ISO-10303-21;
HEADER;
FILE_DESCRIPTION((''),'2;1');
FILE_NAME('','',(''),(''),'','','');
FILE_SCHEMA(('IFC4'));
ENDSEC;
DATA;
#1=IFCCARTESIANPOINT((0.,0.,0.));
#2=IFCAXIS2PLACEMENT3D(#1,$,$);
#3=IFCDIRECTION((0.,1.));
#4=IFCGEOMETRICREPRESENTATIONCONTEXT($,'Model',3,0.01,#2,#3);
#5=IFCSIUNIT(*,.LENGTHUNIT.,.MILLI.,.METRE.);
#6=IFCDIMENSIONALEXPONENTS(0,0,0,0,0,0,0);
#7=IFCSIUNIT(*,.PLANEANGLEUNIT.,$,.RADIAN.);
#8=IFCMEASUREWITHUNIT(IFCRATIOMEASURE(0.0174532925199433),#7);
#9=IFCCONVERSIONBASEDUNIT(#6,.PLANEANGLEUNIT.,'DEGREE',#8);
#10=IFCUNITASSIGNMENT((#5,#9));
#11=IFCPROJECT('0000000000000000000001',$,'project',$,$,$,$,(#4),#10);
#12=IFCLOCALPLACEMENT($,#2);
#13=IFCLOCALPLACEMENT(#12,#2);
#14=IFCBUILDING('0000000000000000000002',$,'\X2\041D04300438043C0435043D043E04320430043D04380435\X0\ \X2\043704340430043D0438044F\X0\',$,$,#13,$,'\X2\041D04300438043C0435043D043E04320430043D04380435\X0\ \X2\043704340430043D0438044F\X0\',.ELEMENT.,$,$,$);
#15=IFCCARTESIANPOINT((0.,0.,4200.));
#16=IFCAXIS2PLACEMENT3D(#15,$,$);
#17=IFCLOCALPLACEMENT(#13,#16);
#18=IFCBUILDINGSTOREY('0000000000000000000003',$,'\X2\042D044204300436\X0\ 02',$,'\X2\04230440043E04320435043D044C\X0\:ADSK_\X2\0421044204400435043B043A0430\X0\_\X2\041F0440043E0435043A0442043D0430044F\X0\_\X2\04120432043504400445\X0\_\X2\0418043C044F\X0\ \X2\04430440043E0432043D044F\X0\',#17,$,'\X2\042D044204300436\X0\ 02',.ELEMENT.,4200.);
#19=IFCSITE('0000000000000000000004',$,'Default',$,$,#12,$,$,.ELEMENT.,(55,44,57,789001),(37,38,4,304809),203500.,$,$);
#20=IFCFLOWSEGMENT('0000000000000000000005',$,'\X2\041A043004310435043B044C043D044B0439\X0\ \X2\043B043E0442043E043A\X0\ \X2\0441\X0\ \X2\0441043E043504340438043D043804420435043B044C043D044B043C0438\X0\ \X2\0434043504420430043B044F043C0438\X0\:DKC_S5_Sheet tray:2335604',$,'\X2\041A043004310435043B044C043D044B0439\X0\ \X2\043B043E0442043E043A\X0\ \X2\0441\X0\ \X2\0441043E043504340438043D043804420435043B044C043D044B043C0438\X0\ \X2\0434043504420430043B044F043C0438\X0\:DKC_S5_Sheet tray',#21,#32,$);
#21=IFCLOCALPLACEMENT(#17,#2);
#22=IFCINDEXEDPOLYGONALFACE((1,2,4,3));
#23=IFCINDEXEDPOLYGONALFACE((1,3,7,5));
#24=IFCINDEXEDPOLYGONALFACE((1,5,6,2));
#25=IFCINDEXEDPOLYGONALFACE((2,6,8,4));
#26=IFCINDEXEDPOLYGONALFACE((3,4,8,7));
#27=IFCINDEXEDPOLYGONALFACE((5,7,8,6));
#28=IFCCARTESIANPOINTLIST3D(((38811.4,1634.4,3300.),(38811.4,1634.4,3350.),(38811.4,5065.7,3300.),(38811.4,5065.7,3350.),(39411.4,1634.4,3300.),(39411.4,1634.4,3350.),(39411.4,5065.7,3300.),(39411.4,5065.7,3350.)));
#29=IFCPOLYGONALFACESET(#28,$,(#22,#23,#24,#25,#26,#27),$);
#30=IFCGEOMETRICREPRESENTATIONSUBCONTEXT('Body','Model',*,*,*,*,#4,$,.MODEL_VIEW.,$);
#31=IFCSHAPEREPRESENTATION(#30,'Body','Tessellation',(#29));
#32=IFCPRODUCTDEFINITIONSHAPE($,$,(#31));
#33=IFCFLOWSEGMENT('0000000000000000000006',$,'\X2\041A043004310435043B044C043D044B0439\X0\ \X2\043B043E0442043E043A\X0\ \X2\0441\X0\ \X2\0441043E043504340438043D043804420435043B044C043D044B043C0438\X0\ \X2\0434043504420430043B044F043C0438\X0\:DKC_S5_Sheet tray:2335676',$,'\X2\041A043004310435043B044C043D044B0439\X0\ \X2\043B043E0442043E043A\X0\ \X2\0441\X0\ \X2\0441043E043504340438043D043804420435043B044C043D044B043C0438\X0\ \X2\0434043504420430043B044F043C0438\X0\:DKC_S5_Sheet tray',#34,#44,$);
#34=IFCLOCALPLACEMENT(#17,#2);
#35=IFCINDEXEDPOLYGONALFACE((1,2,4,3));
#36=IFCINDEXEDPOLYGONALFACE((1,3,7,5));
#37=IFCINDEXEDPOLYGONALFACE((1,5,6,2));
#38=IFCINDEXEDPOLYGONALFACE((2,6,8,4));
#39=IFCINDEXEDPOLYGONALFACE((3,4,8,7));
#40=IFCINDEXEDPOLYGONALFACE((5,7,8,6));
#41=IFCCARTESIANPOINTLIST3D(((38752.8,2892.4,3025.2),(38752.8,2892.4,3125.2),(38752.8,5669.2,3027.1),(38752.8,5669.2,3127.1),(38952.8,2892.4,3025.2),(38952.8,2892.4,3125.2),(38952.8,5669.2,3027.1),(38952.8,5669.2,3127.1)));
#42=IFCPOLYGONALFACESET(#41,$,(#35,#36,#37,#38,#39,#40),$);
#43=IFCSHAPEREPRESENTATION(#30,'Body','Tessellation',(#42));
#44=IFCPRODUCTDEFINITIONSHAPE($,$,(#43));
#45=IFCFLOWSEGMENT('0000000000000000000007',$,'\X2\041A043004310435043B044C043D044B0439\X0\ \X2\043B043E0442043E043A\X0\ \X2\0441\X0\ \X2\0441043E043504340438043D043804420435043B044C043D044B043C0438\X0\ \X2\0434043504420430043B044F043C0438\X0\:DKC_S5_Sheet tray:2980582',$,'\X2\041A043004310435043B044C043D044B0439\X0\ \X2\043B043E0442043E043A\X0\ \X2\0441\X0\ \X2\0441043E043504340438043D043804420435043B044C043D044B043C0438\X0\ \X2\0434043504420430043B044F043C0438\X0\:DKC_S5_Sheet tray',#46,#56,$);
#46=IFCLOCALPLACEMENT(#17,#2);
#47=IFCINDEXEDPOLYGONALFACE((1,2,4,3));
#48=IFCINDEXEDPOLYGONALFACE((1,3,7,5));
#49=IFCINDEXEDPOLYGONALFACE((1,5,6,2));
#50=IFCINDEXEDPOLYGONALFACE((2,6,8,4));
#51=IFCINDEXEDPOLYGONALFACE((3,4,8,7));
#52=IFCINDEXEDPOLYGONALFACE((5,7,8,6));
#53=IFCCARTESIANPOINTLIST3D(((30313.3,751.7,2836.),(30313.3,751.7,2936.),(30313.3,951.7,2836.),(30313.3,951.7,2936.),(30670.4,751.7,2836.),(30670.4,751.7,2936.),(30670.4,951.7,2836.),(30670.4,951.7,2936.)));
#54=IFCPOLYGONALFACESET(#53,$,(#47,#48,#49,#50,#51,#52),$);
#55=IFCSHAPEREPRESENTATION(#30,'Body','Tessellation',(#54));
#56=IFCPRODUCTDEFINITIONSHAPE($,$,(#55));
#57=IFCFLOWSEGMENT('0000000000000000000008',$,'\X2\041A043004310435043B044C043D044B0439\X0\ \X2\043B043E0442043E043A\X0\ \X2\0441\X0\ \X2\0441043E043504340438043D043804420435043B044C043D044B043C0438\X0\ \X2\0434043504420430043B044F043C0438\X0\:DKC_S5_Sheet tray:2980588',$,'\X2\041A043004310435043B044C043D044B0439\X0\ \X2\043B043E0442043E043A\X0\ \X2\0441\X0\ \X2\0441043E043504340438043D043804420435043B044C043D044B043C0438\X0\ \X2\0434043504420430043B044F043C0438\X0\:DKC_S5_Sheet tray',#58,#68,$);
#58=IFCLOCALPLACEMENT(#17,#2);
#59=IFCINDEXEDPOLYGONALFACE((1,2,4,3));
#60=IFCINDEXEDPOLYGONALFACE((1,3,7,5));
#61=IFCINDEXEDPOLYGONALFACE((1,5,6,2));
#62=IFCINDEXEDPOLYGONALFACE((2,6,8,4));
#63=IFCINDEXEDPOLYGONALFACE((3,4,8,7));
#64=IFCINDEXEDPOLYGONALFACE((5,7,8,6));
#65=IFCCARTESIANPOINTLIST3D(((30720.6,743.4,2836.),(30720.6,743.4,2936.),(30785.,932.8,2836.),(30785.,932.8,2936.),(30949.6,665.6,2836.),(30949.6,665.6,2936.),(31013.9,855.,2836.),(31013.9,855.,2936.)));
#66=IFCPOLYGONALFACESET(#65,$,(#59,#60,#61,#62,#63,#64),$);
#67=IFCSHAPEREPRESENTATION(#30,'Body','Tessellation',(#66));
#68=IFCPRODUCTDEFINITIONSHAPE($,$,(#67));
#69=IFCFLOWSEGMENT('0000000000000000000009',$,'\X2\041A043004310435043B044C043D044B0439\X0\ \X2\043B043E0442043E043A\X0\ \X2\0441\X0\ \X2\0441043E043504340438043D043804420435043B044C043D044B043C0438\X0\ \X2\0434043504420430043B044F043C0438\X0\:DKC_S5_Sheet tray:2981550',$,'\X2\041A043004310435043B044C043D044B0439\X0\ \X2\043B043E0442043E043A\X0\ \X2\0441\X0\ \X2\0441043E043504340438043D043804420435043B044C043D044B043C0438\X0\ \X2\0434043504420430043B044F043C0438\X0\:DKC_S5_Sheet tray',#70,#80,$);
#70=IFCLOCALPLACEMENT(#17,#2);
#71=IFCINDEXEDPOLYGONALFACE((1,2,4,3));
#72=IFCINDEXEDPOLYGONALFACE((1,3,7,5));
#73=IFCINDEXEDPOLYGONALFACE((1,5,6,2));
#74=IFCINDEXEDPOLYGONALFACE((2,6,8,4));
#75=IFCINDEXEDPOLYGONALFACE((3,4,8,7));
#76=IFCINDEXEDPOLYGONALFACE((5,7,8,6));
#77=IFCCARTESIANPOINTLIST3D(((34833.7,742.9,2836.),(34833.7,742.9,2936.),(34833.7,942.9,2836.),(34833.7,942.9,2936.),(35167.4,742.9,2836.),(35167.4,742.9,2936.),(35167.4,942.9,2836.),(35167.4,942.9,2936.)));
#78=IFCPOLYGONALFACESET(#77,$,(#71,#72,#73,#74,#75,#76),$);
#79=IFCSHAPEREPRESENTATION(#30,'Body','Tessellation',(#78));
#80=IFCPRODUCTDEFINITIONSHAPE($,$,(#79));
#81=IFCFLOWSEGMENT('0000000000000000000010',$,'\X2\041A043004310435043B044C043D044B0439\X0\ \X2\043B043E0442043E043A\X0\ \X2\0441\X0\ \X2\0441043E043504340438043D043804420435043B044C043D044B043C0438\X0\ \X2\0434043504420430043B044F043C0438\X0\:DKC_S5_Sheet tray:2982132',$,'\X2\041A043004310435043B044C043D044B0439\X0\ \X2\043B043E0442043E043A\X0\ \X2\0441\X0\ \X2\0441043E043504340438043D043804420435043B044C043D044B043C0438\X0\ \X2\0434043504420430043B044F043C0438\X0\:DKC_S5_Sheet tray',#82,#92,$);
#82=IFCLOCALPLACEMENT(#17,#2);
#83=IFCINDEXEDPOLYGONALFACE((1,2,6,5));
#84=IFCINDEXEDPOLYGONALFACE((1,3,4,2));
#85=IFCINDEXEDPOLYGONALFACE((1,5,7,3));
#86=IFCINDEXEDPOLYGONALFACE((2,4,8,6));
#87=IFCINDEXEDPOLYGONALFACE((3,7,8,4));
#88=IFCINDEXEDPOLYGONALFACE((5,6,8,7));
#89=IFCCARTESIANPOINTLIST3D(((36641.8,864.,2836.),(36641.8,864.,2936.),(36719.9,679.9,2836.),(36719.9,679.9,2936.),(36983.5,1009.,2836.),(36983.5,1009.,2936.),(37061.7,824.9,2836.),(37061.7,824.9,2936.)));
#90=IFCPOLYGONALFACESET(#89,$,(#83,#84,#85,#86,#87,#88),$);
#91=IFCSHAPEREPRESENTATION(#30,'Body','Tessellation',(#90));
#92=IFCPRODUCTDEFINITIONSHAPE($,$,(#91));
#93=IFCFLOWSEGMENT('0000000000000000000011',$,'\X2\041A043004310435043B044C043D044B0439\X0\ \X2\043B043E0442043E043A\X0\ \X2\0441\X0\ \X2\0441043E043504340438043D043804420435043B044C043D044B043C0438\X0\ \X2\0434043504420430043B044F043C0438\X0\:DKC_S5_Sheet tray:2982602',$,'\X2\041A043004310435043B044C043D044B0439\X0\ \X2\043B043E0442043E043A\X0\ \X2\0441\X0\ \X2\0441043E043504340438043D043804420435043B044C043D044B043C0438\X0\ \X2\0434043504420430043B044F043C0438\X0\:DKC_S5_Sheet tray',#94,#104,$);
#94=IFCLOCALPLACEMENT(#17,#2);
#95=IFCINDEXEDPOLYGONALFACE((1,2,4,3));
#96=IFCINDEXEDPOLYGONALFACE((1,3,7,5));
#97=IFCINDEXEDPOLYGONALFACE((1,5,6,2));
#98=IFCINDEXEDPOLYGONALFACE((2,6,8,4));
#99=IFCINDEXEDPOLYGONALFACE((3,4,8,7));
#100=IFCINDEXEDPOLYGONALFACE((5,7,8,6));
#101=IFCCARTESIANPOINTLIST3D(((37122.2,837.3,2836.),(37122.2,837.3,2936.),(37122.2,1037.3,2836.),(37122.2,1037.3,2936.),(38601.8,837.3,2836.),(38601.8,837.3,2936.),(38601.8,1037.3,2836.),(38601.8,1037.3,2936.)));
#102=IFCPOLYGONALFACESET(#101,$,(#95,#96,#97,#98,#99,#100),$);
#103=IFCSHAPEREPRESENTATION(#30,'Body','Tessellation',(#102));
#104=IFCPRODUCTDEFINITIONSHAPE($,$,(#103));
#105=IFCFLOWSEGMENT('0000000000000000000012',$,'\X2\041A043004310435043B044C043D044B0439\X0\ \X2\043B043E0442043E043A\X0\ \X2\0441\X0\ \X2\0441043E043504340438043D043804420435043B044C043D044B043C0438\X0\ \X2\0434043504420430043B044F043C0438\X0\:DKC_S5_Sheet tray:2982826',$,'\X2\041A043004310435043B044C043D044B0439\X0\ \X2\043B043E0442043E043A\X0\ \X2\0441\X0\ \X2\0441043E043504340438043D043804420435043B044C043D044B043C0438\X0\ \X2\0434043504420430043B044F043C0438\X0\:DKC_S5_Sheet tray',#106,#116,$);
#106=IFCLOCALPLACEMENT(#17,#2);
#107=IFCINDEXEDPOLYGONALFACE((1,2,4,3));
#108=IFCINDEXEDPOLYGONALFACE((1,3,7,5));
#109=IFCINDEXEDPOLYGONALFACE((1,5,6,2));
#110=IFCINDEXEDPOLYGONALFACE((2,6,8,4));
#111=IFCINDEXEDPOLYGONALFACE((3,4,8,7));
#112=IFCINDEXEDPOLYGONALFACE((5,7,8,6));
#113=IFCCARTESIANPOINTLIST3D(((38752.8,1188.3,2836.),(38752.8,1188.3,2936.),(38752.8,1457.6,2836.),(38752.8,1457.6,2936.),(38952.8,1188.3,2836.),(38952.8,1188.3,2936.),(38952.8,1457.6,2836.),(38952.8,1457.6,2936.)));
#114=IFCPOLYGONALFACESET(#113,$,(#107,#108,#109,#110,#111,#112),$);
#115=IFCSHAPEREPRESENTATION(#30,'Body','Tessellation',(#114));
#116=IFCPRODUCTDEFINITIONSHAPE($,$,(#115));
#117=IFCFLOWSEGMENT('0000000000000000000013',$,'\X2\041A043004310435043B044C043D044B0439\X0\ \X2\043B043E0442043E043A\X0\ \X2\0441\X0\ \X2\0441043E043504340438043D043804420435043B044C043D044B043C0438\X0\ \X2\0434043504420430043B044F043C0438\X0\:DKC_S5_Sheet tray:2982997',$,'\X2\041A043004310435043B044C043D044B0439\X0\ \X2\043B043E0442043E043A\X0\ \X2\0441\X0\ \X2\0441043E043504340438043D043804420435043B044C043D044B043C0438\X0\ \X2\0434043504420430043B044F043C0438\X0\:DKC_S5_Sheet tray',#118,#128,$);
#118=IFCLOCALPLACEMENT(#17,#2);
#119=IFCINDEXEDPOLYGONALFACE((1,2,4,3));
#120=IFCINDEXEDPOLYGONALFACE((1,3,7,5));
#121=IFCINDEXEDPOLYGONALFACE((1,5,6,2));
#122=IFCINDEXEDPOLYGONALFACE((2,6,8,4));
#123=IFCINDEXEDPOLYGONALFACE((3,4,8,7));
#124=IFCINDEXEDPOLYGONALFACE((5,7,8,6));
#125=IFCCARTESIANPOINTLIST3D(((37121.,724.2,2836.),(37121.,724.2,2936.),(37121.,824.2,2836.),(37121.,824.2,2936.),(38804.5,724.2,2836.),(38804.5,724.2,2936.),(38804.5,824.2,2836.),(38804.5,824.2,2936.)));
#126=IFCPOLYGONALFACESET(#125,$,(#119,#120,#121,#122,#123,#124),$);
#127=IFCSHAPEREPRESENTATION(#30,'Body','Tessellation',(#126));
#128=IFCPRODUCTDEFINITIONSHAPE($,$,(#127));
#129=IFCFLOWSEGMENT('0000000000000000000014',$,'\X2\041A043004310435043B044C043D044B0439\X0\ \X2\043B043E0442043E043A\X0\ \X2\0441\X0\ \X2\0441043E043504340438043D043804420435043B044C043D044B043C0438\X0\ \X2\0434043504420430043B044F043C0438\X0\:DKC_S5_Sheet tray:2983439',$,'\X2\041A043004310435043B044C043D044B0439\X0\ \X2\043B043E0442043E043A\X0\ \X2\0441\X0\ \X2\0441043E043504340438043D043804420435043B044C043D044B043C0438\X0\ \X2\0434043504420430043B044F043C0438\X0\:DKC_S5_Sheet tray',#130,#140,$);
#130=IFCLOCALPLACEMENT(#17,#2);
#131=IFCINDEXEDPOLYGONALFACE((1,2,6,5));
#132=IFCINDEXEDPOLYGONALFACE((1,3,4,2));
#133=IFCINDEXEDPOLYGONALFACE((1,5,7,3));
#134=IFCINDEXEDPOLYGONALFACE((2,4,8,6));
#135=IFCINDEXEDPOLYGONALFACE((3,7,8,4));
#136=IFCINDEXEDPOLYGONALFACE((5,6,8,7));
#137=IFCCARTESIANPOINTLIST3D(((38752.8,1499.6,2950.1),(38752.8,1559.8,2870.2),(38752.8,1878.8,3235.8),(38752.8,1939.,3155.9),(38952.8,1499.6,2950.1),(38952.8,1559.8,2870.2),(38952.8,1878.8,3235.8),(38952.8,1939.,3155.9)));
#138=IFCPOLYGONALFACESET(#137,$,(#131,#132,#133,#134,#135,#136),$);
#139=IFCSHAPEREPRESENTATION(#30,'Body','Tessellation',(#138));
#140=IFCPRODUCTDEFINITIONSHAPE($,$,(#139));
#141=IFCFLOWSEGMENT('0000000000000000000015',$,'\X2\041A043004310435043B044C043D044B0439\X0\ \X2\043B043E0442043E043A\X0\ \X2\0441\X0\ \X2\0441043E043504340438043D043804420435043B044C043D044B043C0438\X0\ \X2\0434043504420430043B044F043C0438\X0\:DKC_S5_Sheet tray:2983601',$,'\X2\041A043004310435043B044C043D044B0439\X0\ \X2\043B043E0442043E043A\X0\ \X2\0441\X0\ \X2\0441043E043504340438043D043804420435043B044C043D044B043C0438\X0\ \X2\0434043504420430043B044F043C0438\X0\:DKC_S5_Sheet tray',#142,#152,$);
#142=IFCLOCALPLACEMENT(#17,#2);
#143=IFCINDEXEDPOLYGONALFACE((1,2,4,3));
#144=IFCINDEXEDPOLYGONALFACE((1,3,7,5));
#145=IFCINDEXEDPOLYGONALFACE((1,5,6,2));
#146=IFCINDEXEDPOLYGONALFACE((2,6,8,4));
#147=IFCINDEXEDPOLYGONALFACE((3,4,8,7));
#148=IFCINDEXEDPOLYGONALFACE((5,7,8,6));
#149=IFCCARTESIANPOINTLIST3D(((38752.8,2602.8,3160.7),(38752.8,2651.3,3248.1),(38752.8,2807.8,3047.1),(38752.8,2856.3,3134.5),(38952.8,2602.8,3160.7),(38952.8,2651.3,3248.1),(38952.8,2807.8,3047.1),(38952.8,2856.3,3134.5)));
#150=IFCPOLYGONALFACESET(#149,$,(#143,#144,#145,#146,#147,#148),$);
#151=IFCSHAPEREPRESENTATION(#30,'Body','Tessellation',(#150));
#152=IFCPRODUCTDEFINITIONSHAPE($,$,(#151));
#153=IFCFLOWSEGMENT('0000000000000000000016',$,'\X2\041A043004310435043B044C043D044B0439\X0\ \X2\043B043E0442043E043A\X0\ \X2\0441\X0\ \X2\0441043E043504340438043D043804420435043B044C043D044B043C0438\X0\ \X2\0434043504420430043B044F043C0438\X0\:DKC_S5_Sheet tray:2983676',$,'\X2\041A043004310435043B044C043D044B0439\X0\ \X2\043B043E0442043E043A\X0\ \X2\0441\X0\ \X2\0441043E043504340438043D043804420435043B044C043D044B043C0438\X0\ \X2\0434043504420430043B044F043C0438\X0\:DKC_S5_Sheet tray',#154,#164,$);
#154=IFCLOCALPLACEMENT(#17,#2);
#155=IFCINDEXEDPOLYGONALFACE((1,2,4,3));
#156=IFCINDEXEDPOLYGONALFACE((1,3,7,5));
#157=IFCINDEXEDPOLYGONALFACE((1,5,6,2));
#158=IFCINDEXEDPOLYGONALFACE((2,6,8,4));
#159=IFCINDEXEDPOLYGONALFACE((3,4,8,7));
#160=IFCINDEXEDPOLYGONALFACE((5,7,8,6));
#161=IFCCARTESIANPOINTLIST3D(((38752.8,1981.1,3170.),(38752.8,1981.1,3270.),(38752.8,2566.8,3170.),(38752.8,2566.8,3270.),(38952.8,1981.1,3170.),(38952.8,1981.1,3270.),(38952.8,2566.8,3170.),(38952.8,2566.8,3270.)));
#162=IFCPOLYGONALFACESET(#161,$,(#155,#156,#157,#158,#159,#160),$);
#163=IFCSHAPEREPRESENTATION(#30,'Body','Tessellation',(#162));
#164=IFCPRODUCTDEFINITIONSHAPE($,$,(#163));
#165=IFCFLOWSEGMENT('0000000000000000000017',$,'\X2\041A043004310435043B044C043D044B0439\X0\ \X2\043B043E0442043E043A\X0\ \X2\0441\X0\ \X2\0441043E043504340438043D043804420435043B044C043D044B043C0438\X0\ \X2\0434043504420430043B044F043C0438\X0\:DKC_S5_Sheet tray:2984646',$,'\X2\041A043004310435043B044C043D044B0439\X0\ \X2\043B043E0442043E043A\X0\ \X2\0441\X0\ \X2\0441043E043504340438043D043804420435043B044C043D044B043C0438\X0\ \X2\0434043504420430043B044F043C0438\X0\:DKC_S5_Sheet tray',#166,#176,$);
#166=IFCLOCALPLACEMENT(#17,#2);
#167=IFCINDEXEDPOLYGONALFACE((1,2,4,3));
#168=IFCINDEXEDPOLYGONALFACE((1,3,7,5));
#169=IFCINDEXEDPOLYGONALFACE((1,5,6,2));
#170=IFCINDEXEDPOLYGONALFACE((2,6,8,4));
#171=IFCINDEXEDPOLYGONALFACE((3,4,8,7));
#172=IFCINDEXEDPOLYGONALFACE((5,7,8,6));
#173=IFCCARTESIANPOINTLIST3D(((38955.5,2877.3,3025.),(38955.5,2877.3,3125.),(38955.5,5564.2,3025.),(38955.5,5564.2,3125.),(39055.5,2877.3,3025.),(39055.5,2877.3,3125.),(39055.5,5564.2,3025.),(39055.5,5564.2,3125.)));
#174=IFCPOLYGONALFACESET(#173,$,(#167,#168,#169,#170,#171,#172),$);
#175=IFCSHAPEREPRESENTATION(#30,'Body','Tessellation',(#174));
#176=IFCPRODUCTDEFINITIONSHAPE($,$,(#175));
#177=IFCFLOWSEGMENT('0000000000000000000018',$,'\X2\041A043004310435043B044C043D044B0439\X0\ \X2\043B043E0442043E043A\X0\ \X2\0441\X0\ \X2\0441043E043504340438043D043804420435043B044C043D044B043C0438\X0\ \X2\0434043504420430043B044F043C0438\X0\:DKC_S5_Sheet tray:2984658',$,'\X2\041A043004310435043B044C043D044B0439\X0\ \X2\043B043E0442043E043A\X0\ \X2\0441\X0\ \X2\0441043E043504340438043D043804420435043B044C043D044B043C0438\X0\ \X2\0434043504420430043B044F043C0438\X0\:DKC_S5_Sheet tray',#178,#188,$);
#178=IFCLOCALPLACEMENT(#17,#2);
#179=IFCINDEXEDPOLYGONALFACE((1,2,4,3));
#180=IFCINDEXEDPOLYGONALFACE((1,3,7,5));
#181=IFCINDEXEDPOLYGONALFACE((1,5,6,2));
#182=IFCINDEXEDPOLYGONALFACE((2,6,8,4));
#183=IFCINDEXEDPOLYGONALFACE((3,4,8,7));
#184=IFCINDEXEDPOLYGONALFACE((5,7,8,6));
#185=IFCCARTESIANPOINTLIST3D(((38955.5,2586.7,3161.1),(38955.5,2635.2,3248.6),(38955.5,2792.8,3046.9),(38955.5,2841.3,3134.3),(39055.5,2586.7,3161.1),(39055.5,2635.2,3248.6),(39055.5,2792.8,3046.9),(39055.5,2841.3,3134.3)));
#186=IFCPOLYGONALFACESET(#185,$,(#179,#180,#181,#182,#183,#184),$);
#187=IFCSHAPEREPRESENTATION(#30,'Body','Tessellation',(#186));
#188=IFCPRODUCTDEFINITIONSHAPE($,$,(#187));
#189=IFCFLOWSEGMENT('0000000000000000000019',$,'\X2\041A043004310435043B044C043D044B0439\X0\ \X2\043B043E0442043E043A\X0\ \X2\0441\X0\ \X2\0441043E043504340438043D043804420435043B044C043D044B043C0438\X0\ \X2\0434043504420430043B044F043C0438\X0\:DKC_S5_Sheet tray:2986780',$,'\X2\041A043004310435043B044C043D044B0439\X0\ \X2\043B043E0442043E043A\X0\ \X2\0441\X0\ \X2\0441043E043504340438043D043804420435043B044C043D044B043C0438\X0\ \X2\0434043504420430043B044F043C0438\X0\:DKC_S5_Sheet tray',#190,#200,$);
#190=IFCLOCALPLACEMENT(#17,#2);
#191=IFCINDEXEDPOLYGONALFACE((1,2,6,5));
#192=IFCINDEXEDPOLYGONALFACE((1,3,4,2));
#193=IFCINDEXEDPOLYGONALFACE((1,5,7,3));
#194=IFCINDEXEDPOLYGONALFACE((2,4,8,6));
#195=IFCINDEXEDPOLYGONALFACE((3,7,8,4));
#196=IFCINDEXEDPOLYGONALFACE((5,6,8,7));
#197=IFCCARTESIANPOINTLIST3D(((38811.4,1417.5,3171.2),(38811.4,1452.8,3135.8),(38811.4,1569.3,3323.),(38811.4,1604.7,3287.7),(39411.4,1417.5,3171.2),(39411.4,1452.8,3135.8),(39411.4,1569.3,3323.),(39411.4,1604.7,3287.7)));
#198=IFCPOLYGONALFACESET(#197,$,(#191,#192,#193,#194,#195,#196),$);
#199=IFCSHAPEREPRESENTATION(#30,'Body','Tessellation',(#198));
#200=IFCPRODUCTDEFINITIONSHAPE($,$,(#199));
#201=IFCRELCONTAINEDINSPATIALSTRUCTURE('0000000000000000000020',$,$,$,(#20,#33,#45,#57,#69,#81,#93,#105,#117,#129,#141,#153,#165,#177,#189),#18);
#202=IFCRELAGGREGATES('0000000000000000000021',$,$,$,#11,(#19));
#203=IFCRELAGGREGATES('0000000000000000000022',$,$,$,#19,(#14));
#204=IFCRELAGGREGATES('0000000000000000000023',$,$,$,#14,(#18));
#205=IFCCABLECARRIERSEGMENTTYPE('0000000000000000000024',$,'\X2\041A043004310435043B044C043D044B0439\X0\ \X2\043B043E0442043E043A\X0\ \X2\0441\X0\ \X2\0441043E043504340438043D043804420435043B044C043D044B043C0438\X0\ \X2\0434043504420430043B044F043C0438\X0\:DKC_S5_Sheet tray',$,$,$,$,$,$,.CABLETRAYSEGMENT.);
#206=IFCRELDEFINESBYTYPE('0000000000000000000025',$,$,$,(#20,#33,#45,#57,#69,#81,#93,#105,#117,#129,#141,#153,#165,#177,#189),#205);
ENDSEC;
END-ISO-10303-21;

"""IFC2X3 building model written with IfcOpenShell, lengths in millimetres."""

from ifc_helpers import new_model, entity, si_unit, converted_unit, direction, frame, frame_2d, origin, origin_2d_with_axis, place, context, subcontext, project, spatial, rectangle, extrude, type_object, element, save


model = new_model("IFC2X3")

# Units and contexts
model_context = context("Model", 3, precision=0.01, world=origin(), true_north=direction((0.0, 1.0)))
body_context = subcontext(model_context, "Body", "Model", "MODEL_VIEW")
ifc_project = project(units=[si_unit("LENGTHUNIT", "METRE", prefix="MILLI"), converted_unit("PLANEANGLEUNIT", "DEGREE", entity("IfcRatioMeasure", 0.0174532925199433), si_unit("PLANEANGLEUNIT", "RADIAN"), dimensions=[0, 0, 0, 0, 0, 0, 0])], contexts=[model_context])

# Site, building, storey
site_placement = place(None, frame((0.0, 0.0, 0.0)))
site = spatial("IfcSite", under=ifc_project, at=site_placement, Name="Default", CompositionType="ELEMENT", RefLatitude=(55, 44, 57, 789001), RefLongitude=(37, 38, 4, 304809), RefElevation=203500.0)
building_placement = place(site_placement, origin())
building = spatial("IfcBuilding", under=site, at=building_placement, Name="Наименование здания", LongName="Наименование здания", CompositionType="ELEMENT")
storey_placement = place(building_placement, frame((0.0, 0.0, 4200.0)))
storey = spatial("IfcBuildingStorey", under=building, at=storey_placement, Name="Этаж 02", ObjectType="Уровень:ADSK_Стрелка_Проектная_Вверх_Имя уровня", LongName="Этаж 02", CompositionType="ELEMENT", Elevation=4200.0)

# Flow segments
cable_carrier_segment_type = type_object("IfcCableCarrierSegmentType", Name="Кабельный лоток с соединительными деталями:DKC_S5_Sheet tray", PredefinedType="CABLETRAYSEGMENT")
flow_segment_1_placement = place(storey_placement, frame((38811.4, 1634.4, 3300.0)))
element("IfcFlowSegment", 1, at=flow_segment_1_placement, inside=storey, type_object=cable_carrier_segment_type, Name="Кабельный лоток с соединительными деталями:DKC_S5_Sheet tray:2335604", ObjectType="Кабельный лоток с соединительными деталями:DKC_S5_Sheet tray", context=body_context, shape_type="SweptSolid", body=[
    extrude(rectangle(XDim=3431.2, YDim=600.0, at=origin_2d_with_axis()), frame((300.0, 1715.6, 0.0), z_axis=(0.0, 0.0, 1.0), x_axis=(0.0, -1.0, 0.0)), (0.0, 0.0, 1.0), 50.0),
])
flow_segment_2_placement = place(storey_placement, frame((38752.8, 2892.4, 3025.2)))
element("IfcFlowSegment", 2, at=flow_segment_2_placement, inside=storey, type_object=cable_carrier_segment_type, Name="Кабельный лоток с соединительными деталями:DKC_S5_Sheet tray:2335676", ObjectType="Кабельный лоток с соединительными деталями:DKC_S5_Sheet tray", context=body_context, shape_type="SweptSolid", body=[
    extrude(rectangle(XDim=2776.8, YDim=200.0, at=origin_2d_with_axis()), frame((100.0, 1388.5, 1.0), z_axis=(0.0, -0.000692, 1.0), x_axis=(0.0, -1.0, -0.000692)), (0.0, 0.0, 1.0), 100.0),
])
flow_segment_3_placement = place(storey_placement, frame((30313.3, 751.7, 2836.0)))
element("IfcFlowSegment", 3, at=flow_segment_3_placement, inside=storey, type_object=cable_carrier_segment_type, Name="Кабельный лоток с соединительными деталями:DKC_S5_Sheet tray:2980582", ObjectType="Кабельный лоток с соединительными деталями:DKC_S5_Sheet tray", context=body_context, shape_type="SweptSolid", body=[
    extrude(rectangle(XDim=357.1, YDim=200.0, at=frame_2d((0.0, 0.0), x_axis=(1.0, 0.0))), frame((178.5, 100.0, 0.0)), (0.0, 0.0, 1.0), 100.0),
])
flow_segment_4_placement = place(storey_placement, frame((30720.6, 665.6, 2836.0)))
element("IfcFlowSegment", 4, at=flow_segment_4_placement, inside=storey, type_object=cable_carrier_segment_type, Name="Кабельный лоток с соединительными деталями:DKC_S5_Sheet tray:2980588", ObjectType="Кабельный лоток с соединительными деталями:DKC_S5_Sheet tray", context=body_context, shape_type="SweptSolid", body=[
    extrude(rectangle(XDim=241.8, YDim=200.0, at=frame_2d((0.0, 0.0), x_axis=(1.0, 0.0))), frame((146.6, 133.6, 0.0), z_axis=(0.0, 0.0, 1.0), x_axis=(0.946792, -0.321847, 0.0)), (0.0, 0.0, 1.0), 100.0),
])
flow_segment_5_placement = place(storey_placement, frame((34833.7, 742.9, 2836.0)))
element("IfcFlowSegment", 5, at=flow_segment_5_placement, inside=storey, type_object=cable_carrier_segment_type, Name="Кабельный лоток с соединительными деталями:DKC_S5_Sheet tray:2981550", ObjectType="Кабельный лоток с соединительными деталями:DKC_S5_Sheet tray", context=body_context, shape_type="SweptSolid", body=[
    extrude(rectangle(XDim=333.7, YDim=200.0, at=frame_2d((0.0, 0.0), x_axis=(1.0, 0.0))), frame((166.8, 100.0, 0.0)), (0.0, 0.0, 1.0), 100.0),
])
flow_segment_6_placement = place(storey_placement, frame((36641.8, 679.9, 2836.0)))
element("IfcFlowSegment", 6, at=flow_segment_6_placement, inside=storey, type_object=cable_carrier_segment_type, Name="Кабельный лоток с соединительными деталями:DKC_S5_Sheet tray:2982132", ObjectType="Кабельный лоток с соединительными деталями:DKC_S5_Sheet tray", context=body_context, shape_type="SweptSolid", body=[
    extrude(rectangle(XDim=371.3, YDim=200.0, at=origin_2d_with_axis()), frame((210.0, 164.6, 0.0), z_axis=(0.0, 0.0, 1.0), x_axis=(0.920505, 0.390731, 0.0)), (0.0, 0.0, 1.0), 100.0),
])
flow_segment_7_placement = place(storey_placement, frame((37122.2, 837.3, 2836.0)))
element("IfcFlowSegment", 7, at=flow_segment_7_placement, inside=storey, type_object=cable_carrier_segment_type, Name="Кабельный лоток с соединительными деталями:DKC_S5_Sheet tray:2982602", ObjectType="Кабельный лоток с соединительными деталями:DKC_S5_Sheet tray", context=body_context, shape_type="SweptSolid", body=[
    extrude(rectangle(XDim=1479.6, YDim=200.0, at=origin_2d_with_axis()), frame((739.8, 100.0, 0.0)), (0.0, 0.0, 1.0), 100.0),
])
flow_segment_8_placement = place(storey_placement, frame((38752.8, 1188.3, 2836.0)))
element("IfcFlowSegment", 8, at=flow_segment_8_placement, inside=storey, type_object=cable_carrier_segment_type, Name="Кабельный лоток с соединительными деталями:DKC_S5_Sheet tray:2982826", ObjectType="Кабельный лоток с соединительными деталями:DKC_S5_Sheet tray", context=body_context, shape_type="SweptSolid", body=[
    extrude(rectangle(XDim=269.3, YDim=200.0, at=frame_2d((0.0, 0.0), x_axis=(1.0, 0.0))), frame((100.0, 134.6, 0.0), z_axis=(0.0, 0.0, 1.0), x_axis=(0.0, 1.0, 0.0)), (0.0, 0.0, 1.0), 100.0),
])
flow_segment_9_placement = place(storey_placement, frame((37121.0, 724.2, 2836.0)))
element("IfcFlowSegment", 9, at=flow_segment_9_placement, inside=storey, type_object=cable_carrier_segment_type, Name="Кабельный лоток с соединительными деталями:DKC_S5_Sheet tray:2982997", ObjectType="Кабельный лоток с соединительными деталями:DKC_S5_Sheet tray", context=body_context, shape_type="SweptSolid", body=[
    extrude(rectangle(XDim=1683.5, YDim=100.0, at=frame_2d((0.0, 0.0), x_axis=(1.0, 0.0))), frame((841.8, 50.0, 0.0)), (0.0, 0.0, 1.0), 100.0),
])
flow_segment_10_placement = place(storey_placement, frame((38752.8, 1499.6, 2870.2)))
element("IfcFlowSegment", 10, at=flow_segment_10_placement, inside=storey, type_object=cable_carrier_segment_type, Name="Кабельный лоток с соединительными деталями:DKC_S5_Sheet tray:2983439", ObjectType="Кабельный лоток с соединительными деталями:DKC_S5_Sheet tray", context=body_context, shape_type="SweptSolid", body=[
    extrude(rectangle(XDim=100.0, YDim=474.7, at=frame_2d((0.0, 0.0), x_axis=(0.0, 1.0))), frame((0.0, 219.7, 182.8), z_axis=(1.0, 0.0, 0.0), x_axis=(0.0, 0.798636, 0.601815)), (0.0, 0.0, 1.0), 200.0),
])
flow_segment_11_placement = place(storey_placement, frame((38752.8, 2602.8, 3047.1)))
element("IfcFlowSegment", 11, at=flow_segment_11_placement, inside=storey, type_object=cable_carrier_segment_type, Name="Кабельный лоток с соединительными деталями:DKC_S5_Sheet tray:2983601", ObjectType="Кабельный лоток с соединительными деталями:DKC_S5_Sheet tray", context=body_context, shape_type="SweptSolid", body=[
    extrude(rectangle(XDim=100.0, YDim=234.4, at=frame_2d((0.0, 0.0), x_axis=(0.0, 1.0))), frame((0.0, 126.7, 100.5), z_axis=(1.0, 0.0, 0.0), x_axis=(0.0, -0.87462, 0.48481)), (0.0, 0.0, 1.0), 200.0),
])
flow_segment_12_placement = place(storey_placement, frame((38752.8, 1981.1, 3170.0)))
element("IfcFlowSegment", 12, at=flow_segment_12_placement, inside=storey, type_object=cable_carrier_segment_type, Name="Кабельный лоток с соединительными деталями:DKC_S5_Sheet tray:2983676", ObjectType="Кабельный лоток с соединительными деталями:DKC_S5_Sheet tray", context=body_context, shape_type="SweptSolid", body=[
    extrude(rectangle(XDim=585.7, YDim=200.0, at=origin_2d_with_axis()), frame((100.0, 292.9, 0.0), z_axis=(0.0, 0.0, 1.0), x_axis=(0.0, -1.0, 0.0)), (0.0, 0.0, 1.0), 100.0),
])
flow_segment_13_placement = place(storey_placement, frame((38955.5, 2877.3, 3025.0)))
element("IfcFlowSegment", 13, at=flow_segment_13_placement, inside=storey, type_object=cable_carrier_segment_type, Name="Кабельный лоток с соединительными деталями:DKC_S5_Sheet tray:2984646", ObjectType="Кабельный лоток с соединительными деталями:DKC_S5_Sheet tray", context=body_context, shape_type="SweptSolid", body=[
    extrude(rectangle(XDim=2686.8, YDim=100.0, at=frame_2d((0.0, 0.0), x_axis=(1.0, 0.0))), frame((50.0, 1343.4, 0.0), z_axis=(0.0, 0.0, 1.0), x_axis=(0.0, -1.0, 0.0)), (0.0, 0.0, 1.0), 100.0),
])
flow_segment_14_placement = place(storey_placement, frame((38955.5, 2586.7, 3046.9)))
element("IfcFlowSegment", 14, at=flow_segment_14_placement, inside=storey, type_object=cable_carrier_segment_type, Name="Кабельный лоток с соединительными деталями:DKC_S5_Sheet tray:2984658", ObjectType="Кабельный лоток с соединительными деталями:DKC_S5_Sheet tray", context=body_context, shape_type="SweptSolid", body=[
    extrude(rectangle(XDim=100.0, YDim=100.0, at=frame_2d((0.0, 0.0), x_axis=(1.0, 0.0))), frame((50.0, 24.2, 158.0), z_axis=(0.0, 0.87462, -0.48481), x_axis=(0.0, 0.48481, 0.87462)), (0.0, 0.0, 1.0), 235.7),
])
flow_segment_15_placement = place(storey_placement, frame((38811.4, 1417.5, 3135.8)))
element("IfcFlowSegment", 15, at=flow_segment_15_placement, inside=storey, type_object=cable_carrier_segment_type, Name="Кабельный лоток с соединительными деталями:DKC_S5_Sheet tray:2986780", ObjectType="Кабельный лоток с соединительными деталями:DKC_S5_Sheet tray", context=body_context, shape_type="SweptSolid", body=[
    extrude(rectangle(XDim=50.0, YDim=214.8, at=frame_2d((0.0, 0.0), x_axis=(0.0, 1.0))), frame((0.0, 93.6, 93.6), z_axis=(1.0, 0.0, 0.0), x_axis=(0.0, -0.707107, -0.707107)), (0.0, 0.0, 1.0), 600.0),
])

save(model, "model.ifc")
